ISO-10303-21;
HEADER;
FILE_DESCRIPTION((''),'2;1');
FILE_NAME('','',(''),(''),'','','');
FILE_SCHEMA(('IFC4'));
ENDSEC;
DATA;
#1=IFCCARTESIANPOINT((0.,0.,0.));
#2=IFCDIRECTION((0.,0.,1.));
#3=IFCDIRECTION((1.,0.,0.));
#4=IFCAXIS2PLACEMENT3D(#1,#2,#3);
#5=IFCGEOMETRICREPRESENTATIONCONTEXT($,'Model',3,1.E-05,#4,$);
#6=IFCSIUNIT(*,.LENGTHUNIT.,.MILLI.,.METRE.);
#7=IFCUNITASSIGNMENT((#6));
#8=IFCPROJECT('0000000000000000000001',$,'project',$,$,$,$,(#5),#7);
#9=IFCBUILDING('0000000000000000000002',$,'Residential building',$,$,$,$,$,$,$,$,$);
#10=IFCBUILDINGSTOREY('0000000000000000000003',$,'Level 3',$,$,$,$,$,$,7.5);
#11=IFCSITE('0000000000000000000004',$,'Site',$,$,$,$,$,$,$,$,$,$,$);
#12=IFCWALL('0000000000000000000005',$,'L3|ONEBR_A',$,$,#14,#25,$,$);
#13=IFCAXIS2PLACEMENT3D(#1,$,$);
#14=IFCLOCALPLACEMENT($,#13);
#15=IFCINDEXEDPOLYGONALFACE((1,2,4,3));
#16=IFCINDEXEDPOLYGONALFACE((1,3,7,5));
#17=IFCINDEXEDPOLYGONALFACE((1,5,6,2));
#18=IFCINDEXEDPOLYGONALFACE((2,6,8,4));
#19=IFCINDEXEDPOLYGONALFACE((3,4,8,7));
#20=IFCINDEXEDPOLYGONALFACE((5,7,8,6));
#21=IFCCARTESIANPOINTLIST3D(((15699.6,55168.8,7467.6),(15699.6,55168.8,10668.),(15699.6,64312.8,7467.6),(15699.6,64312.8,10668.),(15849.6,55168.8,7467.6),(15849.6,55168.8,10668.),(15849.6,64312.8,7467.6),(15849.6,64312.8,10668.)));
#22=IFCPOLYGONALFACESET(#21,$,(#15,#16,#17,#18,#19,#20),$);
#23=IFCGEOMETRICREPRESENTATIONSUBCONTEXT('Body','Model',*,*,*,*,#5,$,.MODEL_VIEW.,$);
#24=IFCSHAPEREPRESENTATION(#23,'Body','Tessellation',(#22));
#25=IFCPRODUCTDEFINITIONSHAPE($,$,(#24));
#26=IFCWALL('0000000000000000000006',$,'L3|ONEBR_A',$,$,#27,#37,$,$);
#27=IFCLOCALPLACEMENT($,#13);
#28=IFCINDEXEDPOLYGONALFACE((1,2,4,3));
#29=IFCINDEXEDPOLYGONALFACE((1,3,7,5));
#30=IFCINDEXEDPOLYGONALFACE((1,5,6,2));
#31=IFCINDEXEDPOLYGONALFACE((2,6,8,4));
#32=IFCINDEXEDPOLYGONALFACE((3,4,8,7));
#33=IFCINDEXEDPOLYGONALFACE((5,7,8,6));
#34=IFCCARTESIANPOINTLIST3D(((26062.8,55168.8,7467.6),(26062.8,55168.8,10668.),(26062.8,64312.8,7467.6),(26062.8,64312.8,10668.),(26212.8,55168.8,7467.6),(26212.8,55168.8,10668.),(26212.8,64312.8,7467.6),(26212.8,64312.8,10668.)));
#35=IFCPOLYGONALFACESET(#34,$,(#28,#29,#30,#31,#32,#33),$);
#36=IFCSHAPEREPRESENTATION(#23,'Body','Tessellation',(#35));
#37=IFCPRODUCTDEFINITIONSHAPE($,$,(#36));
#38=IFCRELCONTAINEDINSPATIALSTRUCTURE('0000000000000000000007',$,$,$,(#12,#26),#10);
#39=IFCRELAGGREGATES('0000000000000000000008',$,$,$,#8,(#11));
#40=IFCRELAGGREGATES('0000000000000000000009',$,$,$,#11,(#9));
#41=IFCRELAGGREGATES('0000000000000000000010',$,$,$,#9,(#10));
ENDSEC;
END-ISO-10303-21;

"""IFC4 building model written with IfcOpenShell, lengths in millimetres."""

from ifc_helpers import new_model, si_unit, frame, origin_with_axes, place, context, subcontext, project, spatial, indexed_curve, outline, extrude, element, save


model = new_model("IFC4")

# Units and contexts
model_context = context("Model", 3, precision=1e-05, world=origin_with_axes())
body_context = subcontext(model_context, "Body", "Model", "MODEL_VIEW")
ifc_project = project(units=[si_unit("LENGTHUNIT", "METRE", prefix="MILLI")], contexts=[model_context])

# Site, building, storey
site = spatial("IfcSite", under=ifc_project, Name="Site")
building = spatial("IfcBuilding", under=site, Name="Residential building")
storey = spatial("IfcBuildingStorey", under=building, Name="Level 3", Elevation=7.5)

# Walls
for number, where, z_axis, x_axis, name in (
    (1, (15849.6, 55168.8, 7467.6), (0.0, 0.0, 1.0), (0.0, 1.0, 0.0), "L3|ONEBR_A"),
    (2, (26212.8, 55168.8, 7467.6), (0.0, 0.0, 1.0), (0.0, 1.0, 0.0), "L3|ONEBR_A"),
):
    element("IfcWall", number, at=place(None, frame(where, z_axis=z_axis, x_axis=x_axis)), inside=storey, Name=name, context=body_context, shape_type="SweptSolid", body=[
        extrude(outline(indexed_curve([(0.0, 0.0), (0.0, 150.0), (9144.0, 150.0), (9144.0, 0.0), (0.0, 0.0)], self_intersect=False)), origin_with_axes(), (0.0, 0.0, 1.0), 3200.4),
    ])

save(model, "model.ifc")
